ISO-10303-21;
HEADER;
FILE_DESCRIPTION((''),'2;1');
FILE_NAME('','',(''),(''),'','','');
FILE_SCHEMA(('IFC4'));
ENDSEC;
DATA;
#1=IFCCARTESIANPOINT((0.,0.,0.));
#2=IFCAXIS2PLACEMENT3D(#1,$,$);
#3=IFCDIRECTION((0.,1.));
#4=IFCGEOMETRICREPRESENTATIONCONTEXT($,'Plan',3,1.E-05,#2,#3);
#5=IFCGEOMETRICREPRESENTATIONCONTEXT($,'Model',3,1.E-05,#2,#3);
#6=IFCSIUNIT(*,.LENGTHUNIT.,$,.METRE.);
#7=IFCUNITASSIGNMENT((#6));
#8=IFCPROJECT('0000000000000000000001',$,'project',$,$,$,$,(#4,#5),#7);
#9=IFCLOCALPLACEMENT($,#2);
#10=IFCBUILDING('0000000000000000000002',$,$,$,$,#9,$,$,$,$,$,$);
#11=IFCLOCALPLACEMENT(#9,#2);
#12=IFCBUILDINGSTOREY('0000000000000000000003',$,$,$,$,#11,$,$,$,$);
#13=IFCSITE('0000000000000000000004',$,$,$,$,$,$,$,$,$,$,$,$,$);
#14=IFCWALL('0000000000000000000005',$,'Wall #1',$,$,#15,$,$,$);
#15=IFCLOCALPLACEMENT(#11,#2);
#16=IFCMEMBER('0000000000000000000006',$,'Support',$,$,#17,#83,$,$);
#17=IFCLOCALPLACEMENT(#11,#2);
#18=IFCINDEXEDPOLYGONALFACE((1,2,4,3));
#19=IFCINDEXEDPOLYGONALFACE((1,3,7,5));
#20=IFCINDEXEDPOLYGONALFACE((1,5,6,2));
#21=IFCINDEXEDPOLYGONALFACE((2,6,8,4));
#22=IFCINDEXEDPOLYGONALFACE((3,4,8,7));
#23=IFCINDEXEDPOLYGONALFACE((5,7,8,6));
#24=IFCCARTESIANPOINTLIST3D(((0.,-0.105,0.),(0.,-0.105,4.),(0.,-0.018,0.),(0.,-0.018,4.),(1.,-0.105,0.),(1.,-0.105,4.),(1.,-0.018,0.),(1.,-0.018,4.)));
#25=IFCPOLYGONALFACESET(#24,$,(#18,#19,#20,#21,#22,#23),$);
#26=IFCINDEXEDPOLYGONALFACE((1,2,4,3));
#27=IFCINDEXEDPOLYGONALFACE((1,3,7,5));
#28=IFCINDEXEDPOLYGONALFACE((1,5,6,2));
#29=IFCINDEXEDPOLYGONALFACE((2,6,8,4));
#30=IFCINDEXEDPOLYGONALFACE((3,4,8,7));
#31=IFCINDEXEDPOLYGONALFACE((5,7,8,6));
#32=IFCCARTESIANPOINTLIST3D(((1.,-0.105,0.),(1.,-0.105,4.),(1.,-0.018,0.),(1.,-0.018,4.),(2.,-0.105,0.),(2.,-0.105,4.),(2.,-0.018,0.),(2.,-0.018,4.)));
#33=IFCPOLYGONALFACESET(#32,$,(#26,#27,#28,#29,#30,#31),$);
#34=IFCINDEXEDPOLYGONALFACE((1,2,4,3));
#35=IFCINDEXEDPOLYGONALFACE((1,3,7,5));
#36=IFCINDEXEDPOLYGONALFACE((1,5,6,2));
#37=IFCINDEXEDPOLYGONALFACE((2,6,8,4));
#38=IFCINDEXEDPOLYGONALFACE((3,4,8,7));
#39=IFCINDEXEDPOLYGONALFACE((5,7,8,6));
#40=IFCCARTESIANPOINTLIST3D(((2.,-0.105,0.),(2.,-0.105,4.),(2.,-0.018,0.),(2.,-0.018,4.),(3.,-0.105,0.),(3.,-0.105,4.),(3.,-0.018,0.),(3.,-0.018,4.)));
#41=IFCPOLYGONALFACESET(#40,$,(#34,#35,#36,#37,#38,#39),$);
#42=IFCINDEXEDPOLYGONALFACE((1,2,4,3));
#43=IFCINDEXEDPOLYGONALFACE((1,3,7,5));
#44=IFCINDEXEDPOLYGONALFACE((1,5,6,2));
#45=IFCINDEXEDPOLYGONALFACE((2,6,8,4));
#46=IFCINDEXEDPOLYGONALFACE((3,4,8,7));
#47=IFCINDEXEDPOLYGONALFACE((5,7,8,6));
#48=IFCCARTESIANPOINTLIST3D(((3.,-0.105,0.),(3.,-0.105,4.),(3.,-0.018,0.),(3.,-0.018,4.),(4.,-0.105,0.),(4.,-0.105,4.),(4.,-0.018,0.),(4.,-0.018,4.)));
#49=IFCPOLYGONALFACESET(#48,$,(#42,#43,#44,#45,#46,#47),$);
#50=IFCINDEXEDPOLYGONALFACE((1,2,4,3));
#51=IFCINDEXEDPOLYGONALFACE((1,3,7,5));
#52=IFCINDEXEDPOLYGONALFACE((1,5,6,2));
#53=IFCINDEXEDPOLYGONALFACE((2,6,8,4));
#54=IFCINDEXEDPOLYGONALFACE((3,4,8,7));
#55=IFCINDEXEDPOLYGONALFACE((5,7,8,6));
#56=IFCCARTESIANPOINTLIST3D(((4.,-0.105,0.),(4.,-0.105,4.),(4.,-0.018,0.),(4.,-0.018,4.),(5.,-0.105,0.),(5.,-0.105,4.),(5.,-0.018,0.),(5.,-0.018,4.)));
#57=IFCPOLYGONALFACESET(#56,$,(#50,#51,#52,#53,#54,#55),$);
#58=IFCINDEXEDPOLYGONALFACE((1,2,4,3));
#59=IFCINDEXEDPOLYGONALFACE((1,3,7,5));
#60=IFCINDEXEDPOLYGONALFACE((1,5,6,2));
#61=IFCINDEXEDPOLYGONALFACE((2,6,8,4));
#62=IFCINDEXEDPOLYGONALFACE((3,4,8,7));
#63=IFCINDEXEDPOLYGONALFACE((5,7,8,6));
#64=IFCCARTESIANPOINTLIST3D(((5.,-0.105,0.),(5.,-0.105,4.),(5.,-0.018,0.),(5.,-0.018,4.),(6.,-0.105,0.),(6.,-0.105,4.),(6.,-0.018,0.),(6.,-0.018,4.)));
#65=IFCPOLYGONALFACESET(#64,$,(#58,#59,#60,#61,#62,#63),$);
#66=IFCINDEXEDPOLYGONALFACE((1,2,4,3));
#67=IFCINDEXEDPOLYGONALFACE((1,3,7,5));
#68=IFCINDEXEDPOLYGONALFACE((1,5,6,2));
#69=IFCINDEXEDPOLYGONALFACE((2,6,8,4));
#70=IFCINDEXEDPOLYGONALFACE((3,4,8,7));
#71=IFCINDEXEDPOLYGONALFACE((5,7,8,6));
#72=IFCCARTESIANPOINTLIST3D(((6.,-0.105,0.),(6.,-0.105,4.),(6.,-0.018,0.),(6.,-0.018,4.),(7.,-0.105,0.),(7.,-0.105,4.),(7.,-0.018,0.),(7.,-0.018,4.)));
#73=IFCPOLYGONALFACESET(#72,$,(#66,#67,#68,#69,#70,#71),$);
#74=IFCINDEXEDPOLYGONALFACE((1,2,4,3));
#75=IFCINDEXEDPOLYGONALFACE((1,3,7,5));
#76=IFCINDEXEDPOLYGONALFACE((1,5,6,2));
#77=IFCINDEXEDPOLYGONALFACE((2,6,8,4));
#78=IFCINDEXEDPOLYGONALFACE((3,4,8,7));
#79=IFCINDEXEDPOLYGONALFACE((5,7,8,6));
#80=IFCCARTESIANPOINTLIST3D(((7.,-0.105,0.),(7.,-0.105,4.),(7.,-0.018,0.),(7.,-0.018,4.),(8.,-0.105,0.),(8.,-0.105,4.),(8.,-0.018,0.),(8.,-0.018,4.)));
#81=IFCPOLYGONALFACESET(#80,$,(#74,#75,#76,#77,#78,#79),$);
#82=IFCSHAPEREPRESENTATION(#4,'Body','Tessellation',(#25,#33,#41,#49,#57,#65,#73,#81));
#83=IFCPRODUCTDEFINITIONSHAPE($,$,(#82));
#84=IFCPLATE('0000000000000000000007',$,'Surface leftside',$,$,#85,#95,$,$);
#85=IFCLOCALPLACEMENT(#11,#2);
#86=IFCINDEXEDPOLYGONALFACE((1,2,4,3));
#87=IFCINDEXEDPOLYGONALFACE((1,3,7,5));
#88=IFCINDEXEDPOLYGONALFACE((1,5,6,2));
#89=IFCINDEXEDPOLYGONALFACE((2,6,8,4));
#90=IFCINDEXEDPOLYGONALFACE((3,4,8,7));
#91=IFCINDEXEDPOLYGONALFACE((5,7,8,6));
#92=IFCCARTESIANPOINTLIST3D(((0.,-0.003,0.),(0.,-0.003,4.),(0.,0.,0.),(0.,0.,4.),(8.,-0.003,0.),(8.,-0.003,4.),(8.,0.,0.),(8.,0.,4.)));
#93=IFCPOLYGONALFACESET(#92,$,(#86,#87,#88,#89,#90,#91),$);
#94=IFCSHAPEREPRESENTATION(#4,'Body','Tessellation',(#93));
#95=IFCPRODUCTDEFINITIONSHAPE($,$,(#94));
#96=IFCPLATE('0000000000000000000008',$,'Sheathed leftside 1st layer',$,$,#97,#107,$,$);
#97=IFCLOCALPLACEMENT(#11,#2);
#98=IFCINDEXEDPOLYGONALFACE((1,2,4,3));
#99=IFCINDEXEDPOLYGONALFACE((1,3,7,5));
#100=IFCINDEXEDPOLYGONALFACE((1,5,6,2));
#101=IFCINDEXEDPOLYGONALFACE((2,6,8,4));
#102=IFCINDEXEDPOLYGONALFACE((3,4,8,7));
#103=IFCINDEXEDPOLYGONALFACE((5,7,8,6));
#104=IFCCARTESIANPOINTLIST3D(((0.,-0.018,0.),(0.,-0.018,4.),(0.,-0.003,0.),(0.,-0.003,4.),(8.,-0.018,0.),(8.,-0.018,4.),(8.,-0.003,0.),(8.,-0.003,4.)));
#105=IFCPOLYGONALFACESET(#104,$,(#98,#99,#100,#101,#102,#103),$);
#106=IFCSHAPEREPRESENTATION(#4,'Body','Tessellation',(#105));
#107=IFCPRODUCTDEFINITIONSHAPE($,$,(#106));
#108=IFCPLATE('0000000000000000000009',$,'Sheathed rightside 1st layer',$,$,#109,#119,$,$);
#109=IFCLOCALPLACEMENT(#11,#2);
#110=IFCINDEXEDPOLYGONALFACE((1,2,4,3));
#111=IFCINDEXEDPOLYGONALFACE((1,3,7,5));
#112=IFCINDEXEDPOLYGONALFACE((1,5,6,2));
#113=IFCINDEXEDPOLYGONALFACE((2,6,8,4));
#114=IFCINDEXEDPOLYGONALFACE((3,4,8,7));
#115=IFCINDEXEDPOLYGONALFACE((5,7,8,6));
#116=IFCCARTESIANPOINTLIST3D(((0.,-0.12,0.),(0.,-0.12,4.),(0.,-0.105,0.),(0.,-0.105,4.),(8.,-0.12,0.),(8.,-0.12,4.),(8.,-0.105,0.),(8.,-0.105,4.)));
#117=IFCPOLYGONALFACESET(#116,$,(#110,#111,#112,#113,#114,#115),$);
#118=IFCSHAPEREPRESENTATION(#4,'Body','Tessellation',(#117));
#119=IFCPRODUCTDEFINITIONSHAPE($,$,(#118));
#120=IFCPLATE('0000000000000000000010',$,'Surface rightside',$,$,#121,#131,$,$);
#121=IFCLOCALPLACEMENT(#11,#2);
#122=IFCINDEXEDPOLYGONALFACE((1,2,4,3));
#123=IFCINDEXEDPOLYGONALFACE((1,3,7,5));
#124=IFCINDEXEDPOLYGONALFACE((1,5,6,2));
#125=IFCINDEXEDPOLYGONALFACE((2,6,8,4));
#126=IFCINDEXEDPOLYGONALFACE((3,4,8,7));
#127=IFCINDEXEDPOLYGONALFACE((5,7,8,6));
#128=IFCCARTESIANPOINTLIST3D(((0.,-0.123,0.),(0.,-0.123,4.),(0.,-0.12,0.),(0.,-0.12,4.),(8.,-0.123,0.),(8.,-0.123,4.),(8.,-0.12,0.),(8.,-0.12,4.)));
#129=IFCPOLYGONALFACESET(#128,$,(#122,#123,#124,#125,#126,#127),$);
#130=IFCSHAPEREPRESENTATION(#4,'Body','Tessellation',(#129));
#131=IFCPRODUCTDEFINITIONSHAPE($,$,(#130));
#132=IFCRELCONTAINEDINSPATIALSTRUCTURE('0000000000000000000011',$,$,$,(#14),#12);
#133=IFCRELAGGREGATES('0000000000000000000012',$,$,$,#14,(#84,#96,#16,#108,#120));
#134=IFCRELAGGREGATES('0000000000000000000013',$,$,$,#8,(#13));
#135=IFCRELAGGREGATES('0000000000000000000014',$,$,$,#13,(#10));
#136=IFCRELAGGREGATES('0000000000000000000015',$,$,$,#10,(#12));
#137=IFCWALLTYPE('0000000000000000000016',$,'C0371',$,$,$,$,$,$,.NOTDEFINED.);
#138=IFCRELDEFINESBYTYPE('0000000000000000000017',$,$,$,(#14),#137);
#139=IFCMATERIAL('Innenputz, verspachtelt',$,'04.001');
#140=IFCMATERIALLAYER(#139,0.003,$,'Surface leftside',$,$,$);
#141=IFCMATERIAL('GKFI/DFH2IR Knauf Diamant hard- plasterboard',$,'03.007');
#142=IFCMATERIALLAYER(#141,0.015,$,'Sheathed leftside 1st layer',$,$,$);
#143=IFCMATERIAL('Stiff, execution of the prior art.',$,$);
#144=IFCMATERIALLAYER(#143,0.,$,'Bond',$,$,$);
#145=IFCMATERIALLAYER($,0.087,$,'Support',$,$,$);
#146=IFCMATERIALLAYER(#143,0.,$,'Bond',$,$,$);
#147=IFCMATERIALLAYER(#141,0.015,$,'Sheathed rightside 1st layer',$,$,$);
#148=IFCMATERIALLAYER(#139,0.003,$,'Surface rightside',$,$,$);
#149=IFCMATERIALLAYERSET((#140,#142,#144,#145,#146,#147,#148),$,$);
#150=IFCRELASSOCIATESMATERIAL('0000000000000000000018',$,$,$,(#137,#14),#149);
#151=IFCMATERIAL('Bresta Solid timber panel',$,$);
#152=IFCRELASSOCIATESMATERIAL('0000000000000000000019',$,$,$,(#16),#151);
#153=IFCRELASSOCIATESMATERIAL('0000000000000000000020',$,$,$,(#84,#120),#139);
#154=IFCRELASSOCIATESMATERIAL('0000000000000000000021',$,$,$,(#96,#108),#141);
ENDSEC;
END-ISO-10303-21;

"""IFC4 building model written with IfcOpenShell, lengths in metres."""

from ifc_helpers import new_model, si_unit, direction, frame, frame_2d, origin, origin_with_axes, place, context, project, spatial, rectangle, extrude, material, layer, layer_set, type_object, element, aggregate, save


model = new_model("IFC4")

# Units and contexts
plan_context = context("Plan", 3, precision=1e-05, world=origin(), true_north=direction((0.0, 1.0)))
model_context = context("Model", 3, precision=1e-05, world=origin(), true_north=direction((0.0, 1.0)))
ifc_project = project(units=[si_unit("LENGTHUNIT", "METRE")], contexts=[plan_context, model_context])

# Site, building, storey
site = spatial("IfcSite", under=ifc_project)
building_placement = place(None, origin())
building = spatial("IfcBuilding", under=site, at=building_placement)
storey_placement = place(building_placement, origin())
storey = spatial("IfcBuildingStorey", under=building, at=storey_placement)

# Wall, member, plates
ifc_material_1 = material(Name="Innenputz, verspachtelt", Category="04.001")
ifc_layer_1 = layer(ifc_material_1, 0.003, Name="Surface leftside")
ifc_material_2 = material(Name="GKFI/DFH2IR Knauf Diamant hard- plasterboard", Category="03.007")
ifc_layer_2 = layer(ifc_material_2, 0.015, Name="Sheathed leftside 1st layer")
ifc_material_3 = material(Name="Stiff, execution of the prior art.")
ifc_layer_3 = layer(ifc_material_3, 0.0, Name="Bond")
ifc_layer_4 = layer(None, 0.087, Name="Support")
ifc_layer_5 = layer(ifc_material_3, 0.0, Name="Bond")
ifc_layer_6 = layer(ifc_material_2, 0.015, Name="Sheathed rightside 1st layer")
ifc_layer_7 = layer(ifc_material_1, 0.003, Name="Surface rightside")
ifc_layer_set = layer_set([ifc_layer_1, ifc_layer_2, ifc_layer_3, ifc_layer_4, ifc_layer_5, ifc_layer_6, ifc_layer_7])
wall_type = type_object("IfcWallType", Name="C0371", PredefinedType="NOTDEFINED", material=ifc_layer_set)
wall_placement = place(None, frame((0.0, 0.0, 0.0), z_axis=(0.0, -1.0, 0.0), x_axis=(1.0, 0.0, 0.0)))
wall = element("IfcWall", 1, at=wall_placement, inside=storey, type_object=wall_type, material=ifc_layer_set, Name="Wall #1")
ifc_material_4 = material(Name="Bresta Solid timber panel")
member_placement = place(wall_placement, origin())
member = element("IfcMember", 2, at=member_placement, material=ifc_material_4, Name="Support", context=plan_context, shape_type="SweptSolid", body=[
    extrude(rectangle(XDim=1.0, YDim=0.087, at=frame_2d((0.5, 0.0435), x_axis=(1.0, 0.0))), frame((0.0, 4.0, 0.018), z_axis=(0.0, -1.0, 0.0), x_axis=(1.0, 0.0, 0.0)), (0.0, 0.0, 1.0), 4.0),
    extrude(rectangle(XDim=1.0, YDim=0.087, at=frame_2d((0.5, 0.0435), x_axis=(1.0, 0.0))), frame((1.0, 4.0, 0.018), z_axis=(0.0, -1.0, 0.0), x_axis=(1.0, 0.0, 0.0)), (0.0, 0.0, 1.0), 4.0),
    extrude(rectangle(XDim=1.0, YDim=0.087, at=frame_2d((0.5, 0.0435), x_axis=(1.0, 0.0))), frame((2.0, 4.0, 0.018), z_axis=(0.0, -1.0, 0.0), x_axis=(1.0, 0.0, 0.0)), (0.0, 0.0, 1.0), 4.0),
    extrude(rectangle(XDim=1.0, YDim=0.087, at=frame_2d((0.5, 0.0435), x_axis=(1.0, 0.0))), frame((3.0, 4.0, 0.018), z_axis=(0.0, -1.0, 0.0), x_axis=(1.0, 0.0, 0.0)), (0.0, 0.0, 1.0), 4.0),
    extrude(rectangle(XDim=1.0, YDim=0.087, at=frame_2d((0.5, 0.0435), x_axis=(1.0, 0.0))), frame((4.0, 4.0, 0.018), z_axis=(0.0, -1.0, 0.0), x_axis=(1.0, 0.0, 0.0)), (0.0, 0.0, 1.0), 4.0),
    extrude(rectangle(XDim=1.0, YDim=0.087, at=frame_2d((0.5, 0.0435), x_axis=(1.0, 0.0))), frame((5.0, 4.0, 0.018), z_axis=(0.0, -1.0, 0.0), x_axis=(1.0, 0.0, 0.0)), (0.0, 0.0, 1.0), 4.0),
    extrude(rectangle(XDim=1.0, YDim=0.087, at=frame_2d((0.5, 0.0435), x_axis=(1.0, 0.0))), frame((6.0, 4.0, 0.018), z_axis=(0.0, -1.0, 0.0), x_axis=(1.0, 0.0, 0.0)), (0.0, 0.0, 1.0), 4.0),
    extrude(rectangle(XDim=1.0, YDim=0.087, at=frame_2d((0.5, 0.0435), x_axis=(1.0, 0.0))), frame((7.0, 4.0, 0.018), z_axis=(0.0, -1.0, 0.0), x_axis=(1.0, 0.0, 0.0)), (0.0, 0.0, 1.0), 4.0),
])
plate_1_placement = place(wall_placement, origin())
plate_1 = element("IfcPlate", 3, at=plate_1_placement, material=ifc_material_1, Name="Surface leftside", context=plan_context, shape_type="SweptSolid", body=[
    extrude(rectangle(XDim=8.0, YDim=4.0, at=frame_2d((4.0, 2.0), x_axis=(1.0, 0.0))), origin_with_axes(), (0.0, 0.0, 1.0), 0.003),
])
plate_2_placement = place(wall_placement, origin())
plate_2 = element("IfcPlate", 4, at=plate_2_placement, material=ifc_material_2, Name="Sheathed leftside 1st layer", context=plan_context, shape_type="SweptSolid", body=[
    extrude(rectangle(XDim=8.0, YDim=4.0, at=frame_2d((4.0, 2.0), x_axis=(1.0, 0.0))), frame((0.0, 0.0, 0.003), z_axis=(0.0, 0.0, 1.0), x_axis=(1.0, 0.0, 0.0)), (0.0, 0.0, 1.0), 0.015),
])
plate_3_placement = place(wall_placement, origin())
plate_3 = element("IfcPlate", 5, at=plate_3_placement, material=ifc_material_2, Name="Sheathed rightside 1st layer", context=plan_context, shape_type="SweptSolid", body=[
    extrude(rectangle(XDim=8.0, YDim=4.0, at=frame_2d((4.0, 2.0), x_axis=(1.0, 0.0))), frame((0.0, 0.0, 0.105), z_axis=(0.0, 0.0, 1.0), x_axis=(1.0, 0.0, 0.0)), (0.0, 0.0, 1.0), 0.015),
])
plate_4_placement = place(wall_placement, origin())
plate_4 = element("IfcPlate", 6, at=plate_4_placement, material=ifc_material_1, Name="Surface rightside", context=plan_context, shape_type="SweptSolid", body=[
    extrude(rectangle(XDim=8.0, YDim=4.0, at=frame_2d((4.0, 2.0), x_axis=(1.0, 0.0))), frame((0.0, 0.0, 0.12), z_axis=(0.0, 0.0, 1.0), x_axis=(1.0, 0.0, 0.0)), (0.0, 0.0, 1.0), 0.003),
])
aggregate(wall, [plate_1, plate_2, member, plate_3, plate_4])

save(model, "model.ifc")
